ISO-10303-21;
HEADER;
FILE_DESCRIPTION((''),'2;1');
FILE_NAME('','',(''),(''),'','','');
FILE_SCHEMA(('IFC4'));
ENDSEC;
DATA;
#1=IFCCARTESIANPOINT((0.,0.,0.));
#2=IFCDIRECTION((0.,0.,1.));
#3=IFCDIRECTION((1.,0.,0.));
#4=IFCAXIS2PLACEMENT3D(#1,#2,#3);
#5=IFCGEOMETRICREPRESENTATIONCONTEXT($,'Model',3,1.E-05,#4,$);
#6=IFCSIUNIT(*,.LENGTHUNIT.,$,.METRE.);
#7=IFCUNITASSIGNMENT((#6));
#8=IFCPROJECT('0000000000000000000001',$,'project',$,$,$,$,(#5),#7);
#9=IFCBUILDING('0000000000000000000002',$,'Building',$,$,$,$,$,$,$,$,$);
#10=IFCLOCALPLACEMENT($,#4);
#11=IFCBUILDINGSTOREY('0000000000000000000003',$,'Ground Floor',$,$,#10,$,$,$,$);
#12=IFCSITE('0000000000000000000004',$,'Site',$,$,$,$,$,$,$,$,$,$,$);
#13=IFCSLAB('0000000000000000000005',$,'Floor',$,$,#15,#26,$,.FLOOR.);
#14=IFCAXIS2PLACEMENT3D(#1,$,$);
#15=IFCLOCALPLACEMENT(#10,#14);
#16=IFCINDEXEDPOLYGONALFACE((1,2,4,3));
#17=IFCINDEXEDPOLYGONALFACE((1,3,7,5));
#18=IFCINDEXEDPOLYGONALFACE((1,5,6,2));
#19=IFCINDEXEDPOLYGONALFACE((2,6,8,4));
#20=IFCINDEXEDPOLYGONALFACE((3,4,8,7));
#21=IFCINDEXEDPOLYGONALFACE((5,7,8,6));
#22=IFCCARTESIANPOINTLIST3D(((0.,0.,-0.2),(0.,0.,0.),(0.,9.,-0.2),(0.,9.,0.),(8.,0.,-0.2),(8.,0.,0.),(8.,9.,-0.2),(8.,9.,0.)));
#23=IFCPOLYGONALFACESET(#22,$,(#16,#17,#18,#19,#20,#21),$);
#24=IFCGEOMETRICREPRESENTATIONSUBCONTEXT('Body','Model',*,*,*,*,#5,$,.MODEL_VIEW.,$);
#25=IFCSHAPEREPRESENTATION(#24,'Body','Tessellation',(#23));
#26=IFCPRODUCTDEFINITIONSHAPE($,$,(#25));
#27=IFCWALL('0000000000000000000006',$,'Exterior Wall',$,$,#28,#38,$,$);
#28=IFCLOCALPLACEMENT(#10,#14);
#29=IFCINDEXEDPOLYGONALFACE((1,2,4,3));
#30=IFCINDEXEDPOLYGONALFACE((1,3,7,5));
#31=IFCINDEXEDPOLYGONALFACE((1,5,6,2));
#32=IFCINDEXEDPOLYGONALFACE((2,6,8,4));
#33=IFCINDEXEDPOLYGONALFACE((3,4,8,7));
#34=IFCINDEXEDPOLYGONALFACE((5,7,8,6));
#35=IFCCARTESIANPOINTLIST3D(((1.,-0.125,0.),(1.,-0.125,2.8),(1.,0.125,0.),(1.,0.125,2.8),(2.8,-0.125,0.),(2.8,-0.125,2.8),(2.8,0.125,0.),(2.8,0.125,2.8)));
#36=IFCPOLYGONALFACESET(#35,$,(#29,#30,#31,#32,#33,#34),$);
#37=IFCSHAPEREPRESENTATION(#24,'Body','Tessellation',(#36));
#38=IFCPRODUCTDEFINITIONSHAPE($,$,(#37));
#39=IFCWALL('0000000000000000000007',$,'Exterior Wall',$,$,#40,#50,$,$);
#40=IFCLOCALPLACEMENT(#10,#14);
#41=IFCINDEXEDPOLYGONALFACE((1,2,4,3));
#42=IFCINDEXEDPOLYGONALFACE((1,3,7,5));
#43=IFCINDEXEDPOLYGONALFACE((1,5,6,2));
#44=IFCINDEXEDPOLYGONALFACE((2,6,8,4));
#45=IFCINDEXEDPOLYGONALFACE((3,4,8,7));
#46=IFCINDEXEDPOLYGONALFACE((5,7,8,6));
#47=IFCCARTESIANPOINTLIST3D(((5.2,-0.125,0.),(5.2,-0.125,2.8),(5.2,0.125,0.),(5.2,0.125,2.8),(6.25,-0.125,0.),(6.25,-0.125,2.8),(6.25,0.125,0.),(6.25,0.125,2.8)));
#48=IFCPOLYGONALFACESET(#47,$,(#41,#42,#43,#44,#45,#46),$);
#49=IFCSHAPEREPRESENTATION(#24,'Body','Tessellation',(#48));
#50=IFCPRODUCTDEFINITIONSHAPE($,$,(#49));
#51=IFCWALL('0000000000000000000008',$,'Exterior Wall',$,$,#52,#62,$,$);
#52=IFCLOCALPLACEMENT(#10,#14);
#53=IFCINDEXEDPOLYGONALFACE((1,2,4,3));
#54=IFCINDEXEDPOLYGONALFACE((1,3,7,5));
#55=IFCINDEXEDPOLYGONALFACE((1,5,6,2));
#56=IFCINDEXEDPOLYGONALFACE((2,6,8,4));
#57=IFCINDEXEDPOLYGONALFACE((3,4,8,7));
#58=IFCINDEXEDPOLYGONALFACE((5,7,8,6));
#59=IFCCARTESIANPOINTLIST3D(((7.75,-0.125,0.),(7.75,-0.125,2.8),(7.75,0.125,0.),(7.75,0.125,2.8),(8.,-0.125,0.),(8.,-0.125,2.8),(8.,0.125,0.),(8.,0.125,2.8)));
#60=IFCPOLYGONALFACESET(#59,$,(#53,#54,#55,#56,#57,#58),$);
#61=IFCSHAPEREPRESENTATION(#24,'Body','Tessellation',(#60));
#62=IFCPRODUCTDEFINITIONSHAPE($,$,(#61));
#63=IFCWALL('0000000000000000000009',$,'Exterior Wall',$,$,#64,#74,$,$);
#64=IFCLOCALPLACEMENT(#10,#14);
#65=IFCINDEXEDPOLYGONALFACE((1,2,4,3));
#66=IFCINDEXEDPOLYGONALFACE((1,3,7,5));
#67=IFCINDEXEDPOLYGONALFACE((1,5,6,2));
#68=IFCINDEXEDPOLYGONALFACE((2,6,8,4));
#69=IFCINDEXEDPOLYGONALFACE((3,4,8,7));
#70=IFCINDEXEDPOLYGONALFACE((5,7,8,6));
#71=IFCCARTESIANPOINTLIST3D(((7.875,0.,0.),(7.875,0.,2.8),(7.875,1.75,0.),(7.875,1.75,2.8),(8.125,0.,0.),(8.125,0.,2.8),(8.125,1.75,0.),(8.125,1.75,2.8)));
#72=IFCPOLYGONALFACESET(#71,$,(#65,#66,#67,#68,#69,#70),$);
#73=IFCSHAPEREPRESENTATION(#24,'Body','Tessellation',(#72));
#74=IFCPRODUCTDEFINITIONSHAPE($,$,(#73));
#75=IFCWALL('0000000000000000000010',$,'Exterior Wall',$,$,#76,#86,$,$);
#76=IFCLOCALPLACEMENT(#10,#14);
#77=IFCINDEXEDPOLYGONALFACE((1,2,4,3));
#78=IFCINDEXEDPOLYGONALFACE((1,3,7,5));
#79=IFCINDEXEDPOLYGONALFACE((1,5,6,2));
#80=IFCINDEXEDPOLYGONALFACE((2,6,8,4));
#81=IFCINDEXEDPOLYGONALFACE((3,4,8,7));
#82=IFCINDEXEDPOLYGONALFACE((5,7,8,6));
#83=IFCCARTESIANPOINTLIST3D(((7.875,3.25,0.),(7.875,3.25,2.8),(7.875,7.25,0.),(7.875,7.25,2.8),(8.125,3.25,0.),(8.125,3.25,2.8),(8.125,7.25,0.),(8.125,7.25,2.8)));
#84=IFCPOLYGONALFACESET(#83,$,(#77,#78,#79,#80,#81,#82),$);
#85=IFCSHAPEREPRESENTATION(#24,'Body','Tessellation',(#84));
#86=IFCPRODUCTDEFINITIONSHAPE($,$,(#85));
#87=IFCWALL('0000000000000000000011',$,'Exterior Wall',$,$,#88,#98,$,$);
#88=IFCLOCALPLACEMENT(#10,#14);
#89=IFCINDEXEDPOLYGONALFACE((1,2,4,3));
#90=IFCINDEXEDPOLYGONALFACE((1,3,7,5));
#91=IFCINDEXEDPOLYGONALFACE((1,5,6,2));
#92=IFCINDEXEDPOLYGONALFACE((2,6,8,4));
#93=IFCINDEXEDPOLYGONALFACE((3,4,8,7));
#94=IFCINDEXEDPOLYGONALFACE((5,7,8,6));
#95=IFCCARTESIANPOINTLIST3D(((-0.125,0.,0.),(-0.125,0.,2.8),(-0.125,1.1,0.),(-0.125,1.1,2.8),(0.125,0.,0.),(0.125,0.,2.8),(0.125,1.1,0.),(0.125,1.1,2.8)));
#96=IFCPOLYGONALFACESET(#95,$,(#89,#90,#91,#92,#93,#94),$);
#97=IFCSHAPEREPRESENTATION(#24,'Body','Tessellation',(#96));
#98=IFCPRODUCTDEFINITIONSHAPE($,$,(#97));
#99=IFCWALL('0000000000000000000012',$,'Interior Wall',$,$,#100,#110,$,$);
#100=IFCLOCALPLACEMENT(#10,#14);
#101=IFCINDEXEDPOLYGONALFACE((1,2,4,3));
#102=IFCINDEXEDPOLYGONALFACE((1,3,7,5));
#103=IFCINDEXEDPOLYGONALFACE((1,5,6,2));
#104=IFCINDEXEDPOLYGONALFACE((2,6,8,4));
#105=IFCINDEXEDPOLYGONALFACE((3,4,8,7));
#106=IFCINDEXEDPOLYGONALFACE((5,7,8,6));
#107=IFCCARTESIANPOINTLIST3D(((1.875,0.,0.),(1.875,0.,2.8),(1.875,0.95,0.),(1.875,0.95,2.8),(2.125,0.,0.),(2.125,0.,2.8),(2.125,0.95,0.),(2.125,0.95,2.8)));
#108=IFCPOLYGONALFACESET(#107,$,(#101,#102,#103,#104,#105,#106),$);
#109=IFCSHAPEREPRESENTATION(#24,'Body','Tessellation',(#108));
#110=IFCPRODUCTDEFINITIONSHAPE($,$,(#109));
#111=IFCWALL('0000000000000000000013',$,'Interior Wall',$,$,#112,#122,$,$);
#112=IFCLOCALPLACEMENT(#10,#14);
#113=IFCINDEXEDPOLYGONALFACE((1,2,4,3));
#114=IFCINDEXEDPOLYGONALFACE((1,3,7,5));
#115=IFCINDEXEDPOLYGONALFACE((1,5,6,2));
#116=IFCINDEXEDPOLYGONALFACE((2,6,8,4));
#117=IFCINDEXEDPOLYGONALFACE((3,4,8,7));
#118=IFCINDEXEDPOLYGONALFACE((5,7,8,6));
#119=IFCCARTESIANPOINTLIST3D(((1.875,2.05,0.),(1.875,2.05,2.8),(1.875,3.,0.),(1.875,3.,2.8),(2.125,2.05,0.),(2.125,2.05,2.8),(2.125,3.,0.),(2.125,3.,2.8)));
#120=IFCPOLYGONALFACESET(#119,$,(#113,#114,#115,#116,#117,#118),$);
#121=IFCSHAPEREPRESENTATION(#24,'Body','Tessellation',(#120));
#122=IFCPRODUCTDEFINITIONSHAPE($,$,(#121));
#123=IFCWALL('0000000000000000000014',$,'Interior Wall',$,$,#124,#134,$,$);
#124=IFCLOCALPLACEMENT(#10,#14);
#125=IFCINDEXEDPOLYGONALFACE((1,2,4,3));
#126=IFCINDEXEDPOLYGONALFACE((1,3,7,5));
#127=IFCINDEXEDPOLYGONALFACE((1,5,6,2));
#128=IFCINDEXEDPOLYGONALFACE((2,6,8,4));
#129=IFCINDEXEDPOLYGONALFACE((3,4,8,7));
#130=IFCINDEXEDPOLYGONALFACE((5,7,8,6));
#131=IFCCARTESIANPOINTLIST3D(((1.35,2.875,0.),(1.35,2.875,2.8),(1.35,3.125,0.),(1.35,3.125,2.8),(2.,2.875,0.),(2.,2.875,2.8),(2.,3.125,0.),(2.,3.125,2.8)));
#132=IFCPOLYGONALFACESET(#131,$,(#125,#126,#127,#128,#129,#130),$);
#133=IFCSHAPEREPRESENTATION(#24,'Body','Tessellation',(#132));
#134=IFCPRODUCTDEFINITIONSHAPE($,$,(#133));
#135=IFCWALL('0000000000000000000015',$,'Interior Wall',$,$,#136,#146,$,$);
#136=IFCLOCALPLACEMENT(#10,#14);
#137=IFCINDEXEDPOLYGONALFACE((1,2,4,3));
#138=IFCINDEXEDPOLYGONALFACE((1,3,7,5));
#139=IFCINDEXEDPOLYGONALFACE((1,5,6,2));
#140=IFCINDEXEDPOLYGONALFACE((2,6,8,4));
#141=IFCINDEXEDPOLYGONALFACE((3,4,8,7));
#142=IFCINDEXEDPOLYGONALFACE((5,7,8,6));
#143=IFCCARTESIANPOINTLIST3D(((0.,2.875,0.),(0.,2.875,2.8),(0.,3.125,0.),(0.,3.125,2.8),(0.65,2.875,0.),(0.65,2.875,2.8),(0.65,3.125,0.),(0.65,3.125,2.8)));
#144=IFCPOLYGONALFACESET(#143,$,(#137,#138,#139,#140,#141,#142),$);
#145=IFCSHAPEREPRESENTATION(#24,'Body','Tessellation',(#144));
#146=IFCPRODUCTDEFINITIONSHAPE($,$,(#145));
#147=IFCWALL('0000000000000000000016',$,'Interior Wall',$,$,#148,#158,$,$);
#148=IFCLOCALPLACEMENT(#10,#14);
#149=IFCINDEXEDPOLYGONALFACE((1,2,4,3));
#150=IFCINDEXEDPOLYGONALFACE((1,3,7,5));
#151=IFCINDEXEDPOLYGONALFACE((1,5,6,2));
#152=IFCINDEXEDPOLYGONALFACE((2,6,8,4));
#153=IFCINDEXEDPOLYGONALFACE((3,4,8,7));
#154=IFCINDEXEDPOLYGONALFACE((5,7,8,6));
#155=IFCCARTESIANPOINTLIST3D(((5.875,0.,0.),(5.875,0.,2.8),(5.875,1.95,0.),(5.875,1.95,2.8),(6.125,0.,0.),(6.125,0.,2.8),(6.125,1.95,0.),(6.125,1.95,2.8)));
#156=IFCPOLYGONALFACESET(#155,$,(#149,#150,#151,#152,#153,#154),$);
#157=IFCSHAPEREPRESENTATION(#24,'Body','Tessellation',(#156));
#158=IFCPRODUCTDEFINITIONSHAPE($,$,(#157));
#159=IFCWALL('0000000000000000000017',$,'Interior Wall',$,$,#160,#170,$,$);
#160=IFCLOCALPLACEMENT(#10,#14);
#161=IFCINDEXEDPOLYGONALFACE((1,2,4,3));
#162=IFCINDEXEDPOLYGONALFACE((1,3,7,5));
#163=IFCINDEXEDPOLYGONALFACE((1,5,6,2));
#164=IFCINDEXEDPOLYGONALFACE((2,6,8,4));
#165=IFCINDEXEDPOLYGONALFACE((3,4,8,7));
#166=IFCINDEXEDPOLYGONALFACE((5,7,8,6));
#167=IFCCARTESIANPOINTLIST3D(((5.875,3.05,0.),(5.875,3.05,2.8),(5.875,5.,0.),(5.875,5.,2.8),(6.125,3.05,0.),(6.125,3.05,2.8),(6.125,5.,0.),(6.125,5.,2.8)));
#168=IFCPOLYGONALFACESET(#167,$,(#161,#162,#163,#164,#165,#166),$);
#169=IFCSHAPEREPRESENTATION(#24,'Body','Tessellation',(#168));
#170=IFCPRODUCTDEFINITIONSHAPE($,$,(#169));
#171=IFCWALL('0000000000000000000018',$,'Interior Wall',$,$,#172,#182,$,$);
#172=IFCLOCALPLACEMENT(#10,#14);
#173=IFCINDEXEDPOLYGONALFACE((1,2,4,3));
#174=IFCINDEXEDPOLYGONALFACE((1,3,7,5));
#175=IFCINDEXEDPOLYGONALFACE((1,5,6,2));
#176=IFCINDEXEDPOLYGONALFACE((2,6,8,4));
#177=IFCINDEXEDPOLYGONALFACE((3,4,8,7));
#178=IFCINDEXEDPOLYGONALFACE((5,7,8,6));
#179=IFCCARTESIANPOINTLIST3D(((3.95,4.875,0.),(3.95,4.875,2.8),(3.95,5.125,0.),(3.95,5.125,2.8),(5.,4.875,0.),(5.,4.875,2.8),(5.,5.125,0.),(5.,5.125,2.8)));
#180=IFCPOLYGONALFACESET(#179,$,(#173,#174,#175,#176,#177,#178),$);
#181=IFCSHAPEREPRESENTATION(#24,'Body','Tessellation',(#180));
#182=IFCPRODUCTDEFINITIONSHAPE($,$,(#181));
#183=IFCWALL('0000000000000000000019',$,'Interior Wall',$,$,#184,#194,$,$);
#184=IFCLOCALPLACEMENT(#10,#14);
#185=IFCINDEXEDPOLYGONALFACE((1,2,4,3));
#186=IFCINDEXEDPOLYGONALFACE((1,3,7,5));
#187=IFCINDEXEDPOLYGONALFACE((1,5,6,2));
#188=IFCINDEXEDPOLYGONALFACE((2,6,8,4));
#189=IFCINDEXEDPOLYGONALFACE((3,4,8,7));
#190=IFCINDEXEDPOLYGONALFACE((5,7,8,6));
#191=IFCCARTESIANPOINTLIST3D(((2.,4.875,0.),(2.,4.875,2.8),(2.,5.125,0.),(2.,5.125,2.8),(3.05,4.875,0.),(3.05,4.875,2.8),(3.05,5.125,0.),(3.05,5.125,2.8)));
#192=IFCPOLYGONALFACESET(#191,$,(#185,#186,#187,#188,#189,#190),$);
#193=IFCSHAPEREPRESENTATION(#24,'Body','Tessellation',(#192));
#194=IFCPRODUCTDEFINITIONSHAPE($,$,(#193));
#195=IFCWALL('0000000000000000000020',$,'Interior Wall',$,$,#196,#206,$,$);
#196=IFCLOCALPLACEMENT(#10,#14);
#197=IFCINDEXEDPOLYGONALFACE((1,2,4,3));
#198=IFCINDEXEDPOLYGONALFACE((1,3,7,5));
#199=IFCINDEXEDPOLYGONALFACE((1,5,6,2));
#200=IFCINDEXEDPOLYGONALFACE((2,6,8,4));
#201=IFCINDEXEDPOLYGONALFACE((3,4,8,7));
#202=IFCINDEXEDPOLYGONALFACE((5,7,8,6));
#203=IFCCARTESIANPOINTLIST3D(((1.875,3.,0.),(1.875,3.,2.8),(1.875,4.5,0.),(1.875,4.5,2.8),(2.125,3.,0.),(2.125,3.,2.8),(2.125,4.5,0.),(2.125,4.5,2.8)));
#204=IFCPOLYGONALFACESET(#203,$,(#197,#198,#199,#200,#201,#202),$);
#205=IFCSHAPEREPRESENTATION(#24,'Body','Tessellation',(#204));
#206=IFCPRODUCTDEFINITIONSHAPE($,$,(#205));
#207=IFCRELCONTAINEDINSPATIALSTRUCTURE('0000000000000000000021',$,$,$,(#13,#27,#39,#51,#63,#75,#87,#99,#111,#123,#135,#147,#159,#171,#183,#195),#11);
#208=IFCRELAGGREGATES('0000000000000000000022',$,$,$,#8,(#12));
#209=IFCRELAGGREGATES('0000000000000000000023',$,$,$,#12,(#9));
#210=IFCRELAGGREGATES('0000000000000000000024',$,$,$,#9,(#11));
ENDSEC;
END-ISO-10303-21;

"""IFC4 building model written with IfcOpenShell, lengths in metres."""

from ifc_helpers import new_model, si_unit, frame, origin_with_axes, place, context, subcontext, project, spatial, indexed_curve, outline, extrude, element, save


model = new_model("IFC4")

# Units and contexts
model_context = context("Model", 3, precision=1e-05, world=origin_with_axes())
body_context = subcontext(model_context, "Body", "Model", "MODEL_VIEW")
ifc_project = project(units=[si_unit("LENGTHUNIT", "METRE")], contexts=[model_context])

# Site, building, storey
site = spatial("IfcSite", under=ifc_project, Name="Site")
building = spatial("IfcBuilding", under=site, Name="Building")
storey_placement = place(None, origin_with_axes())
storey = spatial("IfcBuildingStorey", under=building, at=storey_placement, Name="Ground Floor")

# Slab
slab_placement = place(storey_placement, frame((0.0, 0.0, -0.2), z_axis=(0.0, 0.0, 1.0), x_axis=(1.0, 0.0, 0.0)))
element("IfcSlab", 1, at=slab_placement, inside=storey, Name="Floor", PredefinedType="FLOOR", context=body_context, shape_type="SweptSolid", body=[
    extrude(outline(indexed_curve([(0.0, 0.0), (8.0, 0.0), (8.0, 9.0), (0.0, 9.0)])), None, (0.0, 0.0, 1.0), 0.2),
])

# Walls
wall_1_placement = place(storey_placement, frame((1.0, 0.0, 0.0), z_axis=(0.0, 0.0, 1.0), x_axis=(1.0, 0.0, 0.0)))
element("IfcWall", 2, at=wall_1_placement, inside=storey, Name="Exterior Wall", context=body_context, shape_type="SweptSolid", body=[
    extrude(outline(indexed_curve([(0.0, 0.0), (0.0, 0.25), (1.8, 0.25), (1.8, 0.0), (0.0, 0.0)], self_intersect=False)), frame((0.0, -0.125, 0.0), z_axis=(0.0, 0.0, 1.0), x_axis=(1.0, 0.0, 0.0)), (0.0, 0.0, 1.0), 2.8),
])
wall_2_placement = place(storey_placement, frame((5.2, 0.0, 0.0), z_axis=(0.0, 0.0, 1.0), x_axis=(1.0, 0.0, 0.0)))
element("IfcWall", 3, at=wall_2_placement, inside=storey, Name="Exterior Wall", context=body_context, shape_type="SweptSolid", body=[
    extrude(outline(indexed_curve([(0.0, 0.0), (0.0, 0.25), (1.05, 0.25), (1.05, 0.0), (0.0, 0.0)], self_intersect=False)), frame((0.0, -0.125, 0.0), z_axis=(0.0, 0.0, 1.0), x_axis=(1.0, 0.0, 0.0)), (0.0, 0.0, 1.0), 2.8),
])
wall_3_placement = place(storey_placement, frame((7.75, 0.0, 0.0), z_axis=(0.0, 0.0, 1.0), x_axis=(1.0, 0.0, 0.0)))
element("IfcWall", 4, at=wall_3_placement, inside=storey, Name="Exterior Wall", context=body_context, shape_type="SweptSolid", body=[
    extrude(outline(indexed_curve([(0.0, 0.0), (0.0, 0.25), (0.25, 0.25), (0.25, 0.0), (0.0, 0.0)], self_intersect=False)), frame((0.0, -0.125, 0.0), z_axis=(0.0, 0.0, 1.0), x_axis=(1.0, 0.0, 0.0)), (0.0, 0.0, 1.0), 2.8),
])
wall_4_placement = place(storey_placement, frame((8.0, 0.0, 0.0), z_axis=(0.0, 0.0, 1.0), x_axis=(0.0, 1.0, 0.0)))
element("IfcWall", 5, at=wall_4_placement, inside=storey, Name="Exterior Wall", context=body_context, shape_type="SweptSolid", body=[
    extrude(outline(indexed_curve([(0.0, 0.0), (0.0, 0.25), (1.75, 0.25), (1.75, 0.0), (0.0, 0.0)], self_intersect=False)), frame((0.0, -0.125, 0.0), z_axis=(0.0, 0.0, 1.0), x_axis=(1.0, 0.0, 0.0)), (0.0, 0.0, 1.0), 2.8),
])
wall_5_placement = place(storey_placement, frame((8.0, 3.25, 0.0), z_axis=(0.0, 0.0, 1.0), x_axis=(0.0, 1.0, 0.0)))
element("IfcWall", 6, at=wall_5_placement, inside=storey, Name="Exterior Wall", context=body_context, shape_type="SweptSolid", body=[
    extrude(outline(indexed_curve([(0.0, 0.0), (0.0, 0.25), (4.0, 0.25), (4.0, 0.0), (0.0, 0.0)], self_intersect=False)), frame((0.0, -0.125, 0.0), z_axis=(0.0, 0.0, 1.0), x_axis=(1.0, 0.0, 0.0)), (0.0, 0.0, 1.0), 2.8),
])
wall_6_placement = place(storey_placement, frame((0.0, 1.1, 0.0), z_axis=(0.0, 0.0, 1.0), x_axis=(0.0, -1.0, 0.0)))
element("IfcWall", 7, at=wall_6_placement, inside=storey, Name="Exterior Wall", context=body_context, shape_type="SweptSolid", body=[
    extrude(outline(indexed_curve([(0.0, 0.0), (0.0, 0.25), (1.1, 0.25), (1.1, 0.0), (0.0, 0.0)], self_intersect=False)), frame((0.0, -0.125, 0.0), z_axis=(0.0, 0.0, 1.0), x_axis=(1.0, 0.0, 0.0)), (0.0, 0.0, 1.0), 2.8),
])
wall_7_placement = place(storey_placement, frame((2.0, 0.0, 0.0), z_axis=(0.0, 0.0, 1.0), x_axis=(0.0, 1.0, 0.0)))
element("IfcWall", 8, at=wall_7_placement, inside=storey, Name="Interior Wall", context=body_context, shape_type="SweptSolid", body=[
    extrude(outline(indexed_curve([(0.0, 0.0), (0.0, 0.25), (0.95, 0.25), (0.95, 0.0), (0.0, 0.0)], self_intersect=False)), frame((0.0, -0.125, 0.0), z_axis=(0.0, 0.0, 1.0), x_axis=(1.0, 0.0, 0.0)), (0.0, 0.0, 1.0), 2.8),
])
wall_8_placement = place(storey_placement, frame((2.0, 2.05, 0.0), z_axis=(0.0, 0.0, 1.0), x_axis=(0.0, 1.0, 0.0)))
element("IfcWall", 9, at=wall_8_placement, inside=storey, Name="Interior Wall", context=body_context, shape_type="SweptSolid", body=[
    extrude(outline(indexed_curve([(0.0, 0.0), (0.0, 0.25), (0.95, 0.25), (0.95, 0.0), (0.0, 0.0)], self_intersect=False)), frame((0.0, -0.125, 0.0), z_axis=(0.0, 0.0, 1.0), x_axis=(1.0, 0.0, 0.0)), (0.0, 0.0, 1.0), 2.8),
])
for number, where, z_axis, x_axis, name in (
    (10, (2.0, 3.0, 0.0), (0.0, 0.0, 1.0), (-1.0, 0.0, 0.0), "Interior Wall"),
    (11, (0.65, 3.0, 0.0), (0.0, 0.0, 1.0), (-1.0, 0.0, 0.0), "Interior Wall"),
):
    element("IfcWall", number, at=place(storey_placement, frame(where, z_axis=z_axis, x_axis=x_axis)), inside=storey, Name=name, context=body_context, shape_type="SweptSolid", body=[
        extrude(outline(indexed_curve([(0.0, 0.0), (0.0, 0.25), (0.65, 0.25), (0.65, 0.0), (0.0, 0.0)], self_intersect=False)), frame((0.0, -0.125, 0.0), z_axis=(0.0, 0.0, 1.0), x_axis=(1.0, 0.0, 0.0)), (0.0, 0.0, 1.0), 2.8),
    ])
wall_9_placement = place(storey_placement, frame((6.0, 0.0, 0.0), z_axis=(0.0, 0.0, 1.0), x_axis=(0.0, 1.0, 0.0)))
element("IfcWall", 12, at=wall_9_placement, inside=storey, Name="Interior Wall", context=body_context, shape_type="SweptSolid", body=[
    extrude(outline(indexed_curve([(0.0, 0.0), (0.0, 0.25), (1.95, 0.25), (1.95, 0.0), (0.0, 0.0)], self_intersect=False)), frame((0.0, -0.125, 0.0), z_axis=(0.0, 0.0, 1.0), x_axis=(1.0, 0.0, 0.0)), (0.0, 0.0, 1.0), 2.8),
])
wall_10_placement = place(storey_placement, frame((6.0, 3.05, 0.0), z_axis=(0.0, 0.0, 1.0), x_axis=(0.0, 1.0, 0.0)))
element("IfcWall", 13, at=wall_10_placement, inside=storey, Name="Interior Wall", context=body_context, shape_type="SweptSolid", body=[
    extrude(outline(indexed_curve([(0.0, 0.0), (0.0, 0.25), (1.95, 0.25), (1.95, 0.0), (0.0, 0.0)], self_intersect=False)), frame((0.0, -0.125, 0.0), z_axis=(0.0, 0.0, 1.0), x_axis=(1.0, 0.0, 0.0)), (0.0, 0.0, 1.0), 2.8),
])
for number, where, z_axis, x_axis, name in (
    (14, (5.0, 5.0, 0.0), (0.0, 0.0, 1.0), (-1.0, 0.0, 0.0), "Interior Wall"),
    (15, (3.05, 5.0, 0.0), (0.0, 0.0, 1.0), (-1.0, 0.0, 0.0), "Interior Wall"),
):
    element("IfcWall", number, at=place(storey_placement, frame(where, z_axis=z_axis, x_axis=x_axis)), inside=storey, Name=name, context=body_context, shape_type="SweptSolid", body=[
        extrude(outline(indexed_curve([(0.0, 0.0), (0.0, 0.25), (1.05, 0.25), (1.05, 0.0), (0.0, 0.0)], self_intersect=False)), frame((0.0, -0.125, 0.0), z_axis=(0.0, 0.0, 1.0), x_axis=(1.0, 0.0, 0.0)), (0.0, 0.0, 1.0), 2.8),
    ])
wall_11_placement = place(storey_placement, frame((2.0, 4.5, 0.0), z_axis=(0.0, 0.0, 1.0), x_axis=(0.0, -1.0, 0.0)))
element("IfcWall", 16, at=wall_11_placement, inside=storey, Name="Interior Wall", context=body_context, shape_type="SweptSolid", body=[
    extrude(outline(indexed_curve([(0.0, 0.0), (0.0, 0.25), (1.5, 0.25), (1.5, 0.0), (0.0, 0.0)], self_intersect=False)), frame((0.0, -0.125, 0.0), z_axis=(0.0, 0.0, 1.0), x_axis=(1.0, 0.0, 0.0)), (0.0, 0.0, 1.0), 2.8),
])

save(model, "model.ifc")
